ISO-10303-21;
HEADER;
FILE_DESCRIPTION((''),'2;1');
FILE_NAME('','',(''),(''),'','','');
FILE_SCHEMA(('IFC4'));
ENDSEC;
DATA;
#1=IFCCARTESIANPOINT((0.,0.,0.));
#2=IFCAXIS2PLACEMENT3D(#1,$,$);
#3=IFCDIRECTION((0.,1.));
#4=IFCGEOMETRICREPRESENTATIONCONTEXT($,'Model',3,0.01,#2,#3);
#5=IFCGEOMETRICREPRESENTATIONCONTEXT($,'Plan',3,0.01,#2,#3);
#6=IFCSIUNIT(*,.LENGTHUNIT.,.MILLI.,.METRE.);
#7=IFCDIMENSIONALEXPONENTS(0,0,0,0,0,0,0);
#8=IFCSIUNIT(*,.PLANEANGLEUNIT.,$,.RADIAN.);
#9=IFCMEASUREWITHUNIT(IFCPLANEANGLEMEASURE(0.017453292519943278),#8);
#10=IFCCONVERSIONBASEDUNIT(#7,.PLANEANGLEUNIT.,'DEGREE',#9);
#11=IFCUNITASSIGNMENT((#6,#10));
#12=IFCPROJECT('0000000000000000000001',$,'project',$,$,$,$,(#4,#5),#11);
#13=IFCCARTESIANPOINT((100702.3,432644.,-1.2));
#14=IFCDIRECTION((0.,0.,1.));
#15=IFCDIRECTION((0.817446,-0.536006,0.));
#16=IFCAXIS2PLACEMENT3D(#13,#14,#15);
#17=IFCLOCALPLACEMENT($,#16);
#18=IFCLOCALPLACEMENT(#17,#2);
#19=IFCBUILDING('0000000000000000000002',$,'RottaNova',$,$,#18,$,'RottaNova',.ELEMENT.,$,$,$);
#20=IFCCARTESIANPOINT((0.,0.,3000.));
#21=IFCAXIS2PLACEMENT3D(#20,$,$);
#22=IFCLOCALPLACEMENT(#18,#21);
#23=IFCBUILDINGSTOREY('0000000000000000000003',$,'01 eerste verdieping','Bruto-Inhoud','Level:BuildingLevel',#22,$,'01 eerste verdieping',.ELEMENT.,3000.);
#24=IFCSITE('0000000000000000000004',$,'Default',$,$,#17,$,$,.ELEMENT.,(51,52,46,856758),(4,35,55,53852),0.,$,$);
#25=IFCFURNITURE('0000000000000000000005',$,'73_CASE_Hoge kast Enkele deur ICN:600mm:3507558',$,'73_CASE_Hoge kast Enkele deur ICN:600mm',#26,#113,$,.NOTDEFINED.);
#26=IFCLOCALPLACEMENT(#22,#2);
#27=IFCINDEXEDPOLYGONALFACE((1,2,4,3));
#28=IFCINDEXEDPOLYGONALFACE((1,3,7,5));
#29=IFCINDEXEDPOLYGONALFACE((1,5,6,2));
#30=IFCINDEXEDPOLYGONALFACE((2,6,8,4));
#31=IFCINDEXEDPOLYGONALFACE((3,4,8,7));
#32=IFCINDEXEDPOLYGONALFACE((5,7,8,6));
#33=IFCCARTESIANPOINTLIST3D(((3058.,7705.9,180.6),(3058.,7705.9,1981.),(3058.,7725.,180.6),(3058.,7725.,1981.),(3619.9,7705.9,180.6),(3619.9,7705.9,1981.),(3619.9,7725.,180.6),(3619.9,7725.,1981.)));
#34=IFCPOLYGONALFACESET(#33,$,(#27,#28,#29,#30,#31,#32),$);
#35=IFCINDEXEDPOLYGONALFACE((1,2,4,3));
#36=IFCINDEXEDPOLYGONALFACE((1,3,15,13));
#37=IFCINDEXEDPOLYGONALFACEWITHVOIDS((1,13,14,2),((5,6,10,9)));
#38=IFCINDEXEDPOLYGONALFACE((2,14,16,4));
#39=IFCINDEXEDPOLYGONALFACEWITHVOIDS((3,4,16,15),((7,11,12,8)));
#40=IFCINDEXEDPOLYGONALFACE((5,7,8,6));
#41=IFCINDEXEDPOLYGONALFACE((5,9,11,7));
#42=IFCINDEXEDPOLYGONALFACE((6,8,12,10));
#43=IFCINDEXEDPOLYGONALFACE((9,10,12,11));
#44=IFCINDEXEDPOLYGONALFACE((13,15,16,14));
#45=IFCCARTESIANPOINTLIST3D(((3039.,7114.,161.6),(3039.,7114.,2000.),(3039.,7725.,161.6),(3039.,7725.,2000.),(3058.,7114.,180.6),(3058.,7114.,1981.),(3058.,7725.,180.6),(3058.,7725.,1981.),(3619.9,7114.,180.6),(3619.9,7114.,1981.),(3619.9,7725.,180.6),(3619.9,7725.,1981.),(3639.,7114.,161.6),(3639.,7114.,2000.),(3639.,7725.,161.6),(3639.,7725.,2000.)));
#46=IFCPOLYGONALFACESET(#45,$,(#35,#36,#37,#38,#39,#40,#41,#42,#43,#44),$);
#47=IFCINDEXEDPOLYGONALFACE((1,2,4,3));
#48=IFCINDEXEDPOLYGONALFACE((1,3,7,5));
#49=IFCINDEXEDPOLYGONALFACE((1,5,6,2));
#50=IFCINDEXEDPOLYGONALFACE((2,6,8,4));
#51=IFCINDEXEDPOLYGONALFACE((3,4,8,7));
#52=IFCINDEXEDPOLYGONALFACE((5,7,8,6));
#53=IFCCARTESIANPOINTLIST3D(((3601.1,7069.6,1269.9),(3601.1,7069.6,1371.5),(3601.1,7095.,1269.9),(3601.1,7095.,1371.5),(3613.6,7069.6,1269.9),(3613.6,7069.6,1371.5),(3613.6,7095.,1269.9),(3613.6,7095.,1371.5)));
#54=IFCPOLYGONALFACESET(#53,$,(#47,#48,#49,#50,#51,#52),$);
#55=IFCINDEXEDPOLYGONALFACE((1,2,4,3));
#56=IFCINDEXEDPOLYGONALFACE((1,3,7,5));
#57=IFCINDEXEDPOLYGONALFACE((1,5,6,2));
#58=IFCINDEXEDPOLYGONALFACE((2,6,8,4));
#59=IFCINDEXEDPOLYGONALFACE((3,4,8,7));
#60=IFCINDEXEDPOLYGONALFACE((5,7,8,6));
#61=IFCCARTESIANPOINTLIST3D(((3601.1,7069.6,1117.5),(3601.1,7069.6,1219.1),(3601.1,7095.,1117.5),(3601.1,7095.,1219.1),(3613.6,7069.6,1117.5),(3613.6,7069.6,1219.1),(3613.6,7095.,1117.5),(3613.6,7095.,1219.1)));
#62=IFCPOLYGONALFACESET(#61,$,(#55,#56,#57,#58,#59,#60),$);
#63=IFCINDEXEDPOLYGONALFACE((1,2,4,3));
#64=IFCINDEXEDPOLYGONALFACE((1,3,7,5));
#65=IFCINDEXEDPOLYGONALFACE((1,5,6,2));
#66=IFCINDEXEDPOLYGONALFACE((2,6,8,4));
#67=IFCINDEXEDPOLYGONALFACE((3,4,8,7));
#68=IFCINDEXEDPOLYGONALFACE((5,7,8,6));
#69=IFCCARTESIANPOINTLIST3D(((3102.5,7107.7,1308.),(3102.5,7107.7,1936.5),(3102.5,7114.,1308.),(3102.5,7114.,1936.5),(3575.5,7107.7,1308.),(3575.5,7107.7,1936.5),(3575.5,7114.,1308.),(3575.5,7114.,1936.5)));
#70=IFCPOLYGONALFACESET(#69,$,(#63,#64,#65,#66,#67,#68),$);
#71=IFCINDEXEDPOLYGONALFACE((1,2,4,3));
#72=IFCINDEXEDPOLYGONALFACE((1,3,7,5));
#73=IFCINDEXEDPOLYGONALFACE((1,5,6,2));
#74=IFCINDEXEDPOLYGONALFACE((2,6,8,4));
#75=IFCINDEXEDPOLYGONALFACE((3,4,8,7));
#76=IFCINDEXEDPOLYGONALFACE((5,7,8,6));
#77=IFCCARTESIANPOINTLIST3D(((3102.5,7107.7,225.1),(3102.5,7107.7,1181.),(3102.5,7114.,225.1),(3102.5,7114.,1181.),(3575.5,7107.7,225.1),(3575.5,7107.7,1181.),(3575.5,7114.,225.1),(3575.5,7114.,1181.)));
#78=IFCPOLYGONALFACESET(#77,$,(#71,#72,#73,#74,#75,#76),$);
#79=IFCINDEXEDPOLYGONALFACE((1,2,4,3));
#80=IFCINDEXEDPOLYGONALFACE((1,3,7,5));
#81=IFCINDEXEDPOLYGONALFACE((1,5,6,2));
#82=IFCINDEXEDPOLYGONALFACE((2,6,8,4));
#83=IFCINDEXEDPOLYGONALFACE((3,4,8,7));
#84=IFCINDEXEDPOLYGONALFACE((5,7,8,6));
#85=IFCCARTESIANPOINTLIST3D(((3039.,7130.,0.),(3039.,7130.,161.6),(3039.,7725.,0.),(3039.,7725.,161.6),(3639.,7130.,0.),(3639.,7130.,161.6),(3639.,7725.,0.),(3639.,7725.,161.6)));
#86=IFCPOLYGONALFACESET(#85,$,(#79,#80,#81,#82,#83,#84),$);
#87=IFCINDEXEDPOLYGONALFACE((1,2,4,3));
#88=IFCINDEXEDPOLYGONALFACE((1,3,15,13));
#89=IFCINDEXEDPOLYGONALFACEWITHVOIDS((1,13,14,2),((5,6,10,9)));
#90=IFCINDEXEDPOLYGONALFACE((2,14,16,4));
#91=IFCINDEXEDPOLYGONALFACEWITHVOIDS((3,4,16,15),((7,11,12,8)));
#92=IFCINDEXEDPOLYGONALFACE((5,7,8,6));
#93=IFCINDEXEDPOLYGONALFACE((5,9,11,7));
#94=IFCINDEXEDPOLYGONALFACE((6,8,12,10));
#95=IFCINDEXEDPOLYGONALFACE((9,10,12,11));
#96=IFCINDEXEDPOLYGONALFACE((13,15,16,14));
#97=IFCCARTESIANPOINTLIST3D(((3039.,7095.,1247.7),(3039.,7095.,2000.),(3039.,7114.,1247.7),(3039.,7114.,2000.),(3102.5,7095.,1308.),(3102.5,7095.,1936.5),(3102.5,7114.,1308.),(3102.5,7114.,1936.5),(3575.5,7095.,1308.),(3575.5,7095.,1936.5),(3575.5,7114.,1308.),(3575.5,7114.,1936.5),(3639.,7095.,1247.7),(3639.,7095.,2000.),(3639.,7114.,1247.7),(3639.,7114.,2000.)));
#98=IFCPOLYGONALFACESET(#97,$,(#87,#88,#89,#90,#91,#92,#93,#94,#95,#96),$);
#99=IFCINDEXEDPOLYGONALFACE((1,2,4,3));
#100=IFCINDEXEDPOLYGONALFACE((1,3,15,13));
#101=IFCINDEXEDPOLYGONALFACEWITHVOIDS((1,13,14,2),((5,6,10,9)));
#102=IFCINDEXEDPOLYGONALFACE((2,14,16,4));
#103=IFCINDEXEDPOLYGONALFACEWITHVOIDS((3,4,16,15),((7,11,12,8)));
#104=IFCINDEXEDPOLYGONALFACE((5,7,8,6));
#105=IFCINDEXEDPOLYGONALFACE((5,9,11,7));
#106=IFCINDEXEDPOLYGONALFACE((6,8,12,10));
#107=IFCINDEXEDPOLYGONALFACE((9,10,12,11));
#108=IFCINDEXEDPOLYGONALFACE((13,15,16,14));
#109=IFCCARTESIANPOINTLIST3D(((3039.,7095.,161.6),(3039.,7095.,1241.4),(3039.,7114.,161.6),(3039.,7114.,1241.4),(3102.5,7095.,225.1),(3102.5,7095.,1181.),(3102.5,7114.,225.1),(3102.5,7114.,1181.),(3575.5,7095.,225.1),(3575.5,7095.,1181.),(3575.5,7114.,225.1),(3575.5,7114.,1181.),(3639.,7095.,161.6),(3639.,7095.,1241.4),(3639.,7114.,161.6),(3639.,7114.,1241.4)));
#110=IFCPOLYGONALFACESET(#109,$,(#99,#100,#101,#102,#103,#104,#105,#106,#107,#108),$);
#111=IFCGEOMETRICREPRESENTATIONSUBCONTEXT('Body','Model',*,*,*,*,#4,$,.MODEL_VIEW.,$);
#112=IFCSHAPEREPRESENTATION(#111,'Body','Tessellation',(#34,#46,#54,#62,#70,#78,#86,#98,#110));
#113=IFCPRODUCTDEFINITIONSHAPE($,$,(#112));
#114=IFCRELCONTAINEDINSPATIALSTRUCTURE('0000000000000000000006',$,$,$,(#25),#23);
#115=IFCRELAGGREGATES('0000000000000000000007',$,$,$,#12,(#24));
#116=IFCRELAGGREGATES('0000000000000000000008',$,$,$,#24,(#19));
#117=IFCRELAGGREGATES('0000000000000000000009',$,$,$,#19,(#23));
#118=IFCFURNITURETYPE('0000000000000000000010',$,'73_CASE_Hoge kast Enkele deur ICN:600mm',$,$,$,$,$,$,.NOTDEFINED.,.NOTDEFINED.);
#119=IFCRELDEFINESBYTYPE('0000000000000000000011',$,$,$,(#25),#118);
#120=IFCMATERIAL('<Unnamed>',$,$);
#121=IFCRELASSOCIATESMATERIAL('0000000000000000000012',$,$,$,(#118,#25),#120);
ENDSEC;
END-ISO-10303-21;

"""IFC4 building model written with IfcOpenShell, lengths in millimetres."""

from ifc_helpers import new_model, entity, si_unit, converted_unit, direction, frame, origin, place, context, subcontext, project, spatial, indexed_curve, outline, extrude, source, transform, mapped, material, type_object, type_shapes, element, save


model = new_model("IFC4")

# Units and contexts
model_context = context("Model", 3, precision=0.01, world=origin(), true_north=direction((0.0, 1.0)))
plan_context = context("Plan", 3, precision=0.01, world=origin(), true_north=direction((0.0, 1.0)))
body_context = subcontext(model_context, "Body", "Model", "MODEL_VIEW")
ifc_project = project(units=[si_unit("LENGTHUNIT", "METRE", prefix="MILLI"), converted_unit("PLANEANGLEUNIT", "DEGREE", entity("IfcPlaneAngleMeasure", 0.017453292519943278), si_unit("PLANEANGLEUNIT", "RADIAN"), dimensions=[0, 0, 0, 0, 0, 0, 0])], contexts=[model_context, plan_context])

# Site, building, storey
site_placement = place(None, frame((100702.3, 432644.0, -1.2), z_axis=(0.0, 0.0, 1.0), x_axis=(0.817446, -0.536006, 0.0)))
site = spatial("IfcSite", under=ifc_project, at=site_placement, Name="Default", CompositionType="ELEMENT", RefLatitude=(51, 52, 46, 856758), RefLongitude=(4, 35, 55, 53852), RefElevation=0.0)
building_placement = place(site_placement, origin())
building = spatial("IfcBuilding", under=site, at=building_placement, Name="RottaNova", LongName="RottaNova", CompositionType="ELEMENT")
storey_placement = place(building_placement, frame((0.0, 0.0, 3000.0)))
storey = spatial("IfcBuildingStorey", under=building, at=storey_placement, Name="01 eerste verdieping", Description="Bruto-Inhoud", ObjectType="Level:BuildingLevel", LongName="01 eerste verdieping", CompositionType="ELEMENT", Elevation=3000.0)

# Furniture
ifc_material_1 = material(Name="<Unnamed>")
furniture_type = type_object("IfcFurnitureType", Name="73_CASE_Hoge kast Enkele deur ICN:600mm", AssemblyPlace="NOTDEFINED", PredefinedType="NOTDEFINED", material=ifc_material_1)
shared_shape_1 = source(origin(), body_context, "Body", "SweptSolid", [
    extrude(outline(indexed_curve([(-9.5, -280.9), (9.5, -280.9), (9.5, 280.9), (-9.5, 280.9), (-9.5, -280.9)], self_intersect=False)), frame((18.7, -9.5, 180.6), z_axis=(0.0, 0.0, 1.0), x_axis=(0.0, 1.0, 0.0)), (0.0, 0.0, 1.0), 1800.3),
    extrude(outline(indexed_curve([(-300.0, -919.2), (300.0, -919.2), (300.0, 919.2), (-300.0, 919.2), (-300.0, -919.2)], self_intersect=False), holes=[indexed_curve([(-280.9, 900.2), (281.0, 900.2), (281.0, -900.2), (-280.9, -900.2), (-280.9, 900.2)], self_intersect=False)]), frame((18.7, -610.9, 1080.8), z_axis=(0.0, 1.0, 0.0), x_axis=(-1.0, 0.0, 0.0)), (0.0, 0.0, 1.0), 610.9),
    extrude(outline(indexed_curve([(-12.7, -6.3), (12.7, -6.3), (12.7, 6.3), (-12.7, 6.3), (-12.7, -6.3)], self_intersect=False)), frame((287.1, -642.7, 1269.9), z_axis=(0.0, 0.0, 1.0), x_axis=(0.0, 1.0, 0.0)), (0.0, 0.0, 1.0), 101.6),
    extrude(outline(indexed_curve([(-12.7, -6.3), (12.7, -6.3), (12.7, 6.3), (-12.7, 6.3), (-12.7, -6.3)], self_intersect=False)), frame((287.1, -642.7, 1117.5), z_axis=(0.0, 0.0, 1.0), x_axis=(0.0, 1.0, 0.0)), (0.0, 0.0, 1.0), 101.6),
    extrude(outline(indexed_curve([(-3.2, -236.5), (3.2, -236.5), (3.2, 236.5), (-3.2, 236.5), (-3.2, -236.5)], self_intersect=False)), frame((18.7, -614.1, 1308.0), z_axis=(0.0, 0.0, 1.0), x_axis=(0.0, 1.0, 0.0)), (0.0, 0.0, 1.0), 628.5),
    extrude(outline(indexed_curve([(-3.2, -236.5), (3.2, -236.5), (3.2, 236.5), (-3.2, 236.5), (-3.2, -236.5)], self_intersect=False)), frame((18.7, -614.1, 225.1), z_axis=(0.0, 0.0, 1.0), x_axis=(0.0, 1.0, 0.0)), (0.0, 0.0, 1.0), 956.0),
    extrude(outline(indexed_curve([(-300.0, -297.5), (300.0, -297.5), (300.0, 297.5), (-300.0, 297.5), (-300.0, -297.5)], self_intersect=False)), frame((18.7, -297.5, 0.0), z_axis=(0.0, 0.0, 1.0), x_axis=(-1.0, 0.0, 0.0)), (0.0, 0.0, 1.0), 161.6),
    extrude(outline(indexed_curve([(-376.1, -300.0), (376.1, -300.0), (376.1, 300.0), (-376.1, 300.0), (-376.1, -300.0)], self_intersect=False), holes=[indexed_curve([(-312.6, -236.5), (-312.6, 236.5), (315.8, 236.5), (315.8, -236.5), (-312.6, -236.5)], self_intersect=False)]), frame((18.7, -630.0, 1623.9), z_axis=(0.0, 1.0, 0.0), x_axis=(0.0, 0.0, -1.0)), (0.0, 0.0, 1.0), 19.1),
    extrude(outline(indexed_curve([(-300.0, -539.9), (300.0, -539.9), (300.0, 539.9), (-300.0, 539.9), (-300.0, -539.9)], self_intersect=False), holes=[indexed_curve([(-236.5, 479.6), (236.5, 479.6), (236.5, -476.4), (-236.5, -476.4), (-236.5, 479.6)], self_intersect=False)]), frame((18.7, -630.0, 701.5), z_axis=(0.0, 1.0, 0.0), x_axis=(-1.0, 0.0, 0.0)), (0.0, 0.0, 1.0), 19.1),
])
type_shapes(furniture_type, [shared_shape_1])
for number, where, name in (
    (1, (3320.3, 7725.0, 0.0), "73_CASE_Hoge kast Enkele deur ICN:600mm:3507558"),
):
    element("IfcFurniture", number, at=place(storey_placement, frame(where)), inside=storey, type_object=furniture_type, material=ifc_material_1, Name=name, ObjectType="73_CASE_Hoge kast Enkele deur ICN:600mm", PredefinedType="NOTDEFINED", context=body_context, shape_type="MappedRepresentation", body=[
        mapped(shared_shape_1, transform((0.0, 0.0, 0.0), scale=1.0)),
    ])

save(model, "model.ifc")
